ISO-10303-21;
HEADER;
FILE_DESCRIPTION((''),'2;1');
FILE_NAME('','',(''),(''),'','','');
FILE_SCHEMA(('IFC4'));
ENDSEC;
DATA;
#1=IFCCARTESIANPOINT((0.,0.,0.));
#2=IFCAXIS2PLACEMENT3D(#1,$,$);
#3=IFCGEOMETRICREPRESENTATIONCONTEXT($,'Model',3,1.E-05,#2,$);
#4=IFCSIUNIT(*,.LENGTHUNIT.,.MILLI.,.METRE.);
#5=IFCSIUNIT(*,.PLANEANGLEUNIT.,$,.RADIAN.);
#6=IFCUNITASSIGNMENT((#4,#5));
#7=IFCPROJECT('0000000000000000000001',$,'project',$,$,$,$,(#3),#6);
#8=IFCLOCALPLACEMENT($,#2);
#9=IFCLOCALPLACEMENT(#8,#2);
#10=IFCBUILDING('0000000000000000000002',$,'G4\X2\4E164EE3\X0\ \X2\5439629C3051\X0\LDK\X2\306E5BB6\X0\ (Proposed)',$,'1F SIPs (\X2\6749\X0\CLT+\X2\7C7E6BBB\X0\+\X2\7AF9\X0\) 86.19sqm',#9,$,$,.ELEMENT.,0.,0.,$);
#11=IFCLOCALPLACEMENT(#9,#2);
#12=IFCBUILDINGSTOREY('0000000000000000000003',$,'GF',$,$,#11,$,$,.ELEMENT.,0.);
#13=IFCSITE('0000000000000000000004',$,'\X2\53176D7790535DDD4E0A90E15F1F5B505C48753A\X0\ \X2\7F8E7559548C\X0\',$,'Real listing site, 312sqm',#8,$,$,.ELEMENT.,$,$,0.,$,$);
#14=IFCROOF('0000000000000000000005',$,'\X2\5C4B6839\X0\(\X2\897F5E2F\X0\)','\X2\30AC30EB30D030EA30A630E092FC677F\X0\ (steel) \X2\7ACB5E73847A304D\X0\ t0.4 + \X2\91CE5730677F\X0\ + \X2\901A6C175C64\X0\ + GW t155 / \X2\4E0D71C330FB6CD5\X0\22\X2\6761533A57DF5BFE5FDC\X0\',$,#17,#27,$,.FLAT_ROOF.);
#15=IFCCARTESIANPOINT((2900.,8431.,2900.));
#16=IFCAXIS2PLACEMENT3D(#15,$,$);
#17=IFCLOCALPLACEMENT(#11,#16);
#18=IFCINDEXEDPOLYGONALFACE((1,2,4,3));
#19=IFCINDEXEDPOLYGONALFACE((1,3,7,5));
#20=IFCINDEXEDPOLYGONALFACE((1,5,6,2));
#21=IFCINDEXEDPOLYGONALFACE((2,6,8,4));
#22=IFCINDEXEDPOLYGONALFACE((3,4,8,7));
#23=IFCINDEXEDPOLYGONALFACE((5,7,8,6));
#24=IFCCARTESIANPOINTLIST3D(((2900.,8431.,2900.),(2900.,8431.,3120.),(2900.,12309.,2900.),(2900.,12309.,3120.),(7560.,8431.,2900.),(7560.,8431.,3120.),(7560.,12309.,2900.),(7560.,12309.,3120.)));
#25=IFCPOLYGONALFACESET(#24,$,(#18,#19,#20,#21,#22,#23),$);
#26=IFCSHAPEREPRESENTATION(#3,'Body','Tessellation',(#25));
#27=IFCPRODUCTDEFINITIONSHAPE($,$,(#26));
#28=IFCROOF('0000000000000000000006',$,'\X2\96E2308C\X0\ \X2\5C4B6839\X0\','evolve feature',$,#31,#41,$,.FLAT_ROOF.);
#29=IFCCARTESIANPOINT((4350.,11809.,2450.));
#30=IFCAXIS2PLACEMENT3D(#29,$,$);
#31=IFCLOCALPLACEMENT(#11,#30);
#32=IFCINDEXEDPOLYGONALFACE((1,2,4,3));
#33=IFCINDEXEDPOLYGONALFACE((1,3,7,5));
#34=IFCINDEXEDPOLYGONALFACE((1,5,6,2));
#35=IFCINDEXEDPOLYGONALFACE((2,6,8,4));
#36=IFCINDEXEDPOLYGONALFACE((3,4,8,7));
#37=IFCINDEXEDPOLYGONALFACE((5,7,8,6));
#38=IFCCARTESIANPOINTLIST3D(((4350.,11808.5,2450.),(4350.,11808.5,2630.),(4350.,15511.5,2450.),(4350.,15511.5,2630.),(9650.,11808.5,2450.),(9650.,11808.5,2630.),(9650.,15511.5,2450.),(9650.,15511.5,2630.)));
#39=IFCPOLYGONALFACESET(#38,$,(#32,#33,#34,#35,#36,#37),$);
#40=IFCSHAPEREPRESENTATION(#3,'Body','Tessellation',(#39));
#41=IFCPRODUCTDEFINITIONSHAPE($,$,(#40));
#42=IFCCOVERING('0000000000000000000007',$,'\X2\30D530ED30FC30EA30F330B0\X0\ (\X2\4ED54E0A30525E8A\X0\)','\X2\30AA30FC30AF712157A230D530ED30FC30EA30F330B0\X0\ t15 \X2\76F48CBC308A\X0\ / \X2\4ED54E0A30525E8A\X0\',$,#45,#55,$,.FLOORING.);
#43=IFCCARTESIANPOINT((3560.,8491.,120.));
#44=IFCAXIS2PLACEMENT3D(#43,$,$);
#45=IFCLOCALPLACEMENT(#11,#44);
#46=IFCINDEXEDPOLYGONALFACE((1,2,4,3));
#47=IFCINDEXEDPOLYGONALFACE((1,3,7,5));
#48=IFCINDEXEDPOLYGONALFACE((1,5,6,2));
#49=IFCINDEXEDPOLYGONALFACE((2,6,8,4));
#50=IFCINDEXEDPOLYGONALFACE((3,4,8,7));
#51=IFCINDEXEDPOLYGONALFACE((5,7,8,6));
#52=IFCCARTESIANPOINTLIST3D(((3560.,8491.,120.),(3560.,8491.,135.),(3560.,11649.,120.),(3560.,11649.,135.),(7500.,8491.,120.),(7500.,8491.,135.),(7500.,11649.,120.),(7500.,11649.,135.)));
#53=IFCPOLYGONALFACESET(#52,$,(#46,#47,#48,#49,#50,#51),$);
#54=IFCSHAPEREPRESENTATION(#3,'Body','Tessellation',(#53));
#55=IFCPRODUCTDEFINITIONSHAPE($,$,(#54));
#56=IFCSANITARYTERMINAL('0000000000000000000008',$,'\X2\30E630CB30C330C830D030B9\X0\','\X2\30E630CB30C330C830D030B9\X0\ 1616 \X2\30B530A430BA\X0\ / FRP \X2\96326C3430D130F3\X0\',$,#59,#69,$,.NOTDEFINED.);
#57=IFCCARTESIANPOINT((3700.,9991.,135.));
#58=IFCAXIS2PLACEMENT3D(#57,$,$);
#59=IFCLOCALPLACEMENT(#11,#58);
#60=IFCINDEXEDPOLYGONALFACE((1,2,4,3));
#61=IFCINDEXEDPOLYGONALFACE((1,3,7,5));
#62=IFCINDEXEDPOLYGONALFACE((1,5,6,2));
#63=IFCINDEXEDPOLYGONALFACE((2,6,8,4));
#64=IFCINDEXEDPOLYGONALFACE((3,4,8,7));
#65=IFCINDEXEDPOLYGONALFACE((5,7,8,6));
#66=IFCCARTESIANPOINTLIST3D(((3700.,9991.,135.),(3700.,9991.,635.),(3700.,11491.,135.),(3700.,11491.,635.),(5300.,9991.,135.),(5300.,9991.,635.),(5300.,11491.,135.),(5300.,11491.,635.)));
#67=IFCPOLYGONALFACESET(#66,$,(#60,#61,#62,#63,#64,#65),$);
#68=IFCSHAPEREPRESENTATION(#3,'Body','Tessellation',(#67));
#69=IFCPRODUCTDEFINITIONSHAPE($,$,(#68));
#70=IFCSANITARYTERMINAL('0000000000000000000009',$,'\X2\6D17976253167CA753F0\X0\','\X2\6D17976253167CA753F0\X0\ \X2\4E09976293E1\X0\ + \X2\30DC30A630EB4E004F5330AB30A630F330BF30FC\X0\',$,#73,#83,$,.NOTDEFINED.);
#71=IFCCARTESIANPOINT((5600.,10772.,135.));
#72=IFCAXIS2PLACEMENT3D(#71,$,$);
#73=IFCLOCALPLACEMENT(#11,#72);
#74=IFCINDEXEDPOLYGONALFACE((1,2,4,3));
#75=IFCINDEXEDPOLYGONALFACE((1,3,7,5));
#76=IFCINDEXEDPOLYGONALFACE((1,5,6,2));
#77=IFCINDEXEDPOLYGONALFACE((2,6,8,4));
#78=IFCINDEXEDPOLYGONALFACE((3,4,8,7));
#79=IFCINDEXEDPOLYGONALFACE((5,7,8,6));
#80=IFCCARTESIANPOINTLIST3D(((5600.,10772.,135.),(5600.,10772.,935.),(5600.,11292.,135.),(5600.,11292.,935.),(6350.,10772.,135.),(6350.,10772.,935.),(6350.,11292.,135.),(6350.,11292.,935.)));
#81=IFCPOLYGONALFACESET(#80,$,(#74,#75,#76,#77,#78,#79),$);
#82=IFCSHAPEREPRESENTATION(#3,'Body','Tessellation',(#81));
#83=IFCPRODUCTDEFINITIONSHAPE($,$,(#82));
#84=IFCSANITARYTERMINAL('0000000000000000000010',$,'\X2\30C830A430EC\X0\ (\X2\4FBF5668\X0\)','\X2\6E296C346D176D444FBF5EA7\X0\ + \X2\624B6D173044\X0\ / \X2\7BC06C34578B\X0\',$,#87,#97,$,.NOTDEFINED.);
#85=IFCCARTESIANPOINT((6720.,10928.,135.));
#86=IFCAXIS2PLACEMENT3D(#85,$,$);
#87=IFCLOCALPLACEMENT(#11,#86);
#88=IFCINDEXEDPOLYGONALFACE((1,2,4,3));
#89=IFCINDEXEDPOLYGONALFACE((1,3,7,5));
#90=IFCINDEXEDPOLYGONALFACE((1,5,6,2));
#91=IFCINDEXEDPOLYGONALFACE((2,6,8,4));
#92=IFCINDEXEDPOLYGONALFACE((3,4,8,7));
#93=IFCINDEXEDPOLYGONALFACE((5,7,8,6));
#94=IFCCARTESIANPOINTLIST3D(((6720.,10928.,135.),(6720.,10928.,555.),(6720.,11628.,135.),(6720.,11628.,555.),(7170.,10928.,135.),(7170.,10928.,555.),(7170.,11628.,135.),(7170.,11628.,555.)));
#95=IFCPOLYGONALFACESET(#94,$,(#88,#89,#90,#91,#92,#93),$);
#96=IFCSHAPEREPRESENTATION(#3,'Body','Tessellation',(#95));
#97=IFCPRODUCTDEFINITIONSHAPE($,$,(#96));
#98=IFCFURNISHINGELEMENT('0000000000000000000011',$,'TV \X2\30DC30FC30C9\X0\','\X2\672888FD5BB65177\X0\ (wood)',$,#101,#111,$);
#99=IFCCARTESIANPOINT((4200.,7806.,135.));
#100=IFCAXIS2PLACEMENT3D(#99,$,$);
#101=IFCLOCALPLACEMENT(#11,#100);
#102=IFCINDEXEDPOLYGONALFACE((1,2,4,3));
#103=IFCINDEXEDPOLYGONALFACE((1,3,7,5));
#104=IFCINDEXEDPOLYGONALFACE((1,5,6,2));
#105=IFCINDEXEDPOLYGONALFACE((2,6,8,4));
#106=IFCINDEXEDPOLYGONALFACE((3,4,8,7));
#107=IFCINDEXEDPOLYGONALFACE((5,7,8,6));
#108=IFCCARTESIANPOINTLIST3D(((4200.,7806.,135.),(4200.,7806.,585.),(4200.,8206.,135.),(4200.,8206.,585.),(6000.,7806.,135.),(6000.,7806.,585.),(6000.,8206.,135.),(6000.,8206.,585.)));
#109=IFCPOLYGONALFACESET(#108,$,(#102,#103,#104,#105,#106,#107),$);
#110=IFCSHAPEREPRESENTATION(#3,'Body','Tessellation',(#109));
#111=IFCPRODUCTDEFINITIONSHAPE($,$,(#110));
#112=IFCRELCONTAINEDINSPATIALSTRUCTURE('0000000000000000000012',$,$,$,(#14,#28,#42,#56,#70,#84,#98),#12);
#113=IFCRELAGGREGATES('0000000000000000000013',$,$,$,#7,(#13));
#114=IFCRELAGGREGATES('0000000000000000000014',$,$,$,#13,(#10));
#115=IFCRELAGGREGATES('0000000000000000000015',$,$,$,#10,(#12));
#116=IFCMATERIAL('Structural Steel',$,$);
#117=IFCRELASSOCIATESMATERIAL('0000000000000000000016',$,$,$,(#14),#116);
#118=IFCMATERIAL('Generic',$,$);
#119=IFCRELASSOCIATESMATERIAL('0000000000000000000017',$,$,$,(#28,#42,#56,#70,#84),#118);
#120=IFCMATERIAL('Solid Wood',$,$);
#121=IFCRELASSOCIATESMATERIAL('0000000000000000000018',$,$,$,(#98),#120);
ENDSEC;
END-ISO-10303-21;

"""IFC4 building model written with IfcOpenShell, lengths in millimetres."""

from ifc_helpers import new_model, si_unit, frame, frame_2d, origin, place, context, project, spatial, rectangle, extrude, material, element, save


model = new_model("IFC4")

# Units and contexts
model_context = context("Model", 3, precision=1e-05, world=origin())
ifc_project = project(units=[si_unit("LENGTHUNIT", "METRE", prefix="MILLI"), si_unit("PLANEANGLEUNIT", "RADIAN")], contexts=[model_context])

# Site, building, storey
site_placement = place(None, origin())
site = spatial("IfcSite", under=ifc_project, at=site_placement, Name="北海道川上郡弟子屈町 美留和", ObjectType="Real listing site, 312sqm", CompositionType="ELEMENT", RefElevation=0.0)
building_placement = place(site_placement, origin())
building = spatial("IfcBuilding", under=site, at=building_placement, Name="G4世代 吹抜けLDKの家 (Proposed)", ObjectType="1F SIPs (杉CLT+籾殻+竹) 86.19sqm", CompositionType="ELEMENT", ElevationOfRefHeight=0.0, ElevationOfTerrain=0.0)
storey_placement = place(building_placement, origin())
storey = spatial("IfcBuildingStorey", under=building, at=storey_placement, Name="GF", CompositionType="ELEMENT", Elevation=0.0)

# Shared definitions
ifc_material_1 = material(Name="Solid Wood")
ifc_material_2 = material(Name="Generic")

# Roofs
ifc_material_3 = material(Name="Structural Steel")
roof_1_placement = place(storey_placement, frame((2900.0, 8431.0, 2900.0)))
element("IfcRoof", 1, at=roof_1_placement, inside=storey, material=ifc_material_3, Name="屋根(西帯)", Description="ガルバリウム鋼板 (steel) 立平葺き t0.4 + 野地板 + 通気層 + GW t155 / 不燃・法22条区域対応", PredefinedType="FLAT_ROOF", context=model_context, shape_type="SweptSolid", body=[
    extrude(rectangle(XDim=4660.0, YDim=3878.0, at=frame_2d((2330.0, 1939.0))), frame((2900.0, 8431.0, 2900.0)), (0.0, 0.0, 1.0), 220.0),
])
roof_2_placement = place(storey_placement, frame((4350.0, 11809.0, 2450.0)))
element("IfcRoof", 2, at=roof_2_placement, inside=storey, material=ifc_material_2, Name="離れ 屋根", Description="evolve feature", PredefinedType="FLAT_ROOF", context=model_context, shape_type="SweptSolid", body=[
    extrude(rectangle(XDim=5300.0, YDim=3703.0, at=frame_2d((2650.0, 1851.0))), frame((4350.0, 11809.0, 2450.0)), (0.0, 0.0, 1.0), 180.0),
])

# Covering
covering_placement = place(storey_placement, frame((3560.0, 8491.0, 120.0)))
element("IfcCovering", 3, at=covering_placement, inside=storey, material=ifc_material_2, Name="フローリング (仕上げ床)", Description="オーク無垢フローリング t15 直貼り / 仕上げ床", PredefinedType="FLOORING", context=model_context, shape_type="SweptSolid", body=[
    extrude(rectangle(XDim=3940.0, YDim=3158.0, at=frame_2d((1970.0, 1579.0))), frame((3560.0, 8491.0, 120.0)), (0.0, 0.0, 1.0), 15.0),
])

# Sanitary terminals
sanitary_terminal_1_placement = place(storey_placement, frame((3700.0, 9991.0, 135.0)))
element("IfcSanitaryTerminal", 4, at=sanitary_terminal_1_placement, inside=storey, material=ifc_material_2, Name="ユニットバス", Description="ユニットバス 1616 サイズ / FRP 防水パン", PredefinedType="NOTDEFINED", context=model_context, shape_type="SweptSolid", body=[
    extrude(rectangle(XDim=1600.0, YDim=1500.0, at=frame_2d((800.0, 750.0))), frame((3700.0, 9991.0, 135.0)), (0.0, 0.0, 1.0), 500.0),
])
sanitary_terminal_2_placement = place(storey_placement, frame((5600.0, 10772.0, 135.0)))
element("IfcSanitaryTerminal", 5, at=sanitary_terminal_2_placement, inside=storey, material=ifc_material_2, Name="洗面化粧台", Description="洗面化粧台 三面鏡 + ボウル一体カウンター", PredefinedType="NOTDEFINED", context=model_context, shape_type="SweptSolid", body=[
    extrude(rectangle(XDim=750.0, YDim=520.0, at=frame_2d((375.0, 260.0))), frame((5600.0, 10772.0, 135.0)), (0.0, 0.0, 1.0), 800.0),
])
sanitary_terminal_3_placement = place(storey_placement, frame((6720.0, 10928.0, 135.0)))
element("IfcSanitaryTerminal", 6, at=sanitary_terminal_3_placement, inside=storey, material=ifc_material_2, Name="トイレ (便器)", Description="温水洗浄便座 + 手洗い / 節水型", PredefinedType="NOTDEFINED", context=model_context, shape_type="SweptSolid", body=[
    extrude(rectangle(XDim=450.0, YDim=700.0, at=frame_2d((225.0, 350.0))), frame((6720.0, 10928.0, 135.0)), (0.0, 0.0, 1.0), 420.0),
])

# Furnishing element
furnishing_placement = place(storey_placement, frame((4200.0, 7806.0, 135.0)))
element("IfcFurnishingElement", 7, at=furnishing_placement, inside=storey, material=ifc_material_1, Name="TV ボード", Description="木製家具 (wood)", context=model_context, shape_type="SweptSolid", body=[
    extrude(rectangle(XDim=1800.0, YDim=400.0, at=frame_2d((900.0, 200.0))), frame((4200.0, 7806.0, 135.0)), (0.0, 0.0, 1.0), 450.0),
])

save(model, "model.ifc")
